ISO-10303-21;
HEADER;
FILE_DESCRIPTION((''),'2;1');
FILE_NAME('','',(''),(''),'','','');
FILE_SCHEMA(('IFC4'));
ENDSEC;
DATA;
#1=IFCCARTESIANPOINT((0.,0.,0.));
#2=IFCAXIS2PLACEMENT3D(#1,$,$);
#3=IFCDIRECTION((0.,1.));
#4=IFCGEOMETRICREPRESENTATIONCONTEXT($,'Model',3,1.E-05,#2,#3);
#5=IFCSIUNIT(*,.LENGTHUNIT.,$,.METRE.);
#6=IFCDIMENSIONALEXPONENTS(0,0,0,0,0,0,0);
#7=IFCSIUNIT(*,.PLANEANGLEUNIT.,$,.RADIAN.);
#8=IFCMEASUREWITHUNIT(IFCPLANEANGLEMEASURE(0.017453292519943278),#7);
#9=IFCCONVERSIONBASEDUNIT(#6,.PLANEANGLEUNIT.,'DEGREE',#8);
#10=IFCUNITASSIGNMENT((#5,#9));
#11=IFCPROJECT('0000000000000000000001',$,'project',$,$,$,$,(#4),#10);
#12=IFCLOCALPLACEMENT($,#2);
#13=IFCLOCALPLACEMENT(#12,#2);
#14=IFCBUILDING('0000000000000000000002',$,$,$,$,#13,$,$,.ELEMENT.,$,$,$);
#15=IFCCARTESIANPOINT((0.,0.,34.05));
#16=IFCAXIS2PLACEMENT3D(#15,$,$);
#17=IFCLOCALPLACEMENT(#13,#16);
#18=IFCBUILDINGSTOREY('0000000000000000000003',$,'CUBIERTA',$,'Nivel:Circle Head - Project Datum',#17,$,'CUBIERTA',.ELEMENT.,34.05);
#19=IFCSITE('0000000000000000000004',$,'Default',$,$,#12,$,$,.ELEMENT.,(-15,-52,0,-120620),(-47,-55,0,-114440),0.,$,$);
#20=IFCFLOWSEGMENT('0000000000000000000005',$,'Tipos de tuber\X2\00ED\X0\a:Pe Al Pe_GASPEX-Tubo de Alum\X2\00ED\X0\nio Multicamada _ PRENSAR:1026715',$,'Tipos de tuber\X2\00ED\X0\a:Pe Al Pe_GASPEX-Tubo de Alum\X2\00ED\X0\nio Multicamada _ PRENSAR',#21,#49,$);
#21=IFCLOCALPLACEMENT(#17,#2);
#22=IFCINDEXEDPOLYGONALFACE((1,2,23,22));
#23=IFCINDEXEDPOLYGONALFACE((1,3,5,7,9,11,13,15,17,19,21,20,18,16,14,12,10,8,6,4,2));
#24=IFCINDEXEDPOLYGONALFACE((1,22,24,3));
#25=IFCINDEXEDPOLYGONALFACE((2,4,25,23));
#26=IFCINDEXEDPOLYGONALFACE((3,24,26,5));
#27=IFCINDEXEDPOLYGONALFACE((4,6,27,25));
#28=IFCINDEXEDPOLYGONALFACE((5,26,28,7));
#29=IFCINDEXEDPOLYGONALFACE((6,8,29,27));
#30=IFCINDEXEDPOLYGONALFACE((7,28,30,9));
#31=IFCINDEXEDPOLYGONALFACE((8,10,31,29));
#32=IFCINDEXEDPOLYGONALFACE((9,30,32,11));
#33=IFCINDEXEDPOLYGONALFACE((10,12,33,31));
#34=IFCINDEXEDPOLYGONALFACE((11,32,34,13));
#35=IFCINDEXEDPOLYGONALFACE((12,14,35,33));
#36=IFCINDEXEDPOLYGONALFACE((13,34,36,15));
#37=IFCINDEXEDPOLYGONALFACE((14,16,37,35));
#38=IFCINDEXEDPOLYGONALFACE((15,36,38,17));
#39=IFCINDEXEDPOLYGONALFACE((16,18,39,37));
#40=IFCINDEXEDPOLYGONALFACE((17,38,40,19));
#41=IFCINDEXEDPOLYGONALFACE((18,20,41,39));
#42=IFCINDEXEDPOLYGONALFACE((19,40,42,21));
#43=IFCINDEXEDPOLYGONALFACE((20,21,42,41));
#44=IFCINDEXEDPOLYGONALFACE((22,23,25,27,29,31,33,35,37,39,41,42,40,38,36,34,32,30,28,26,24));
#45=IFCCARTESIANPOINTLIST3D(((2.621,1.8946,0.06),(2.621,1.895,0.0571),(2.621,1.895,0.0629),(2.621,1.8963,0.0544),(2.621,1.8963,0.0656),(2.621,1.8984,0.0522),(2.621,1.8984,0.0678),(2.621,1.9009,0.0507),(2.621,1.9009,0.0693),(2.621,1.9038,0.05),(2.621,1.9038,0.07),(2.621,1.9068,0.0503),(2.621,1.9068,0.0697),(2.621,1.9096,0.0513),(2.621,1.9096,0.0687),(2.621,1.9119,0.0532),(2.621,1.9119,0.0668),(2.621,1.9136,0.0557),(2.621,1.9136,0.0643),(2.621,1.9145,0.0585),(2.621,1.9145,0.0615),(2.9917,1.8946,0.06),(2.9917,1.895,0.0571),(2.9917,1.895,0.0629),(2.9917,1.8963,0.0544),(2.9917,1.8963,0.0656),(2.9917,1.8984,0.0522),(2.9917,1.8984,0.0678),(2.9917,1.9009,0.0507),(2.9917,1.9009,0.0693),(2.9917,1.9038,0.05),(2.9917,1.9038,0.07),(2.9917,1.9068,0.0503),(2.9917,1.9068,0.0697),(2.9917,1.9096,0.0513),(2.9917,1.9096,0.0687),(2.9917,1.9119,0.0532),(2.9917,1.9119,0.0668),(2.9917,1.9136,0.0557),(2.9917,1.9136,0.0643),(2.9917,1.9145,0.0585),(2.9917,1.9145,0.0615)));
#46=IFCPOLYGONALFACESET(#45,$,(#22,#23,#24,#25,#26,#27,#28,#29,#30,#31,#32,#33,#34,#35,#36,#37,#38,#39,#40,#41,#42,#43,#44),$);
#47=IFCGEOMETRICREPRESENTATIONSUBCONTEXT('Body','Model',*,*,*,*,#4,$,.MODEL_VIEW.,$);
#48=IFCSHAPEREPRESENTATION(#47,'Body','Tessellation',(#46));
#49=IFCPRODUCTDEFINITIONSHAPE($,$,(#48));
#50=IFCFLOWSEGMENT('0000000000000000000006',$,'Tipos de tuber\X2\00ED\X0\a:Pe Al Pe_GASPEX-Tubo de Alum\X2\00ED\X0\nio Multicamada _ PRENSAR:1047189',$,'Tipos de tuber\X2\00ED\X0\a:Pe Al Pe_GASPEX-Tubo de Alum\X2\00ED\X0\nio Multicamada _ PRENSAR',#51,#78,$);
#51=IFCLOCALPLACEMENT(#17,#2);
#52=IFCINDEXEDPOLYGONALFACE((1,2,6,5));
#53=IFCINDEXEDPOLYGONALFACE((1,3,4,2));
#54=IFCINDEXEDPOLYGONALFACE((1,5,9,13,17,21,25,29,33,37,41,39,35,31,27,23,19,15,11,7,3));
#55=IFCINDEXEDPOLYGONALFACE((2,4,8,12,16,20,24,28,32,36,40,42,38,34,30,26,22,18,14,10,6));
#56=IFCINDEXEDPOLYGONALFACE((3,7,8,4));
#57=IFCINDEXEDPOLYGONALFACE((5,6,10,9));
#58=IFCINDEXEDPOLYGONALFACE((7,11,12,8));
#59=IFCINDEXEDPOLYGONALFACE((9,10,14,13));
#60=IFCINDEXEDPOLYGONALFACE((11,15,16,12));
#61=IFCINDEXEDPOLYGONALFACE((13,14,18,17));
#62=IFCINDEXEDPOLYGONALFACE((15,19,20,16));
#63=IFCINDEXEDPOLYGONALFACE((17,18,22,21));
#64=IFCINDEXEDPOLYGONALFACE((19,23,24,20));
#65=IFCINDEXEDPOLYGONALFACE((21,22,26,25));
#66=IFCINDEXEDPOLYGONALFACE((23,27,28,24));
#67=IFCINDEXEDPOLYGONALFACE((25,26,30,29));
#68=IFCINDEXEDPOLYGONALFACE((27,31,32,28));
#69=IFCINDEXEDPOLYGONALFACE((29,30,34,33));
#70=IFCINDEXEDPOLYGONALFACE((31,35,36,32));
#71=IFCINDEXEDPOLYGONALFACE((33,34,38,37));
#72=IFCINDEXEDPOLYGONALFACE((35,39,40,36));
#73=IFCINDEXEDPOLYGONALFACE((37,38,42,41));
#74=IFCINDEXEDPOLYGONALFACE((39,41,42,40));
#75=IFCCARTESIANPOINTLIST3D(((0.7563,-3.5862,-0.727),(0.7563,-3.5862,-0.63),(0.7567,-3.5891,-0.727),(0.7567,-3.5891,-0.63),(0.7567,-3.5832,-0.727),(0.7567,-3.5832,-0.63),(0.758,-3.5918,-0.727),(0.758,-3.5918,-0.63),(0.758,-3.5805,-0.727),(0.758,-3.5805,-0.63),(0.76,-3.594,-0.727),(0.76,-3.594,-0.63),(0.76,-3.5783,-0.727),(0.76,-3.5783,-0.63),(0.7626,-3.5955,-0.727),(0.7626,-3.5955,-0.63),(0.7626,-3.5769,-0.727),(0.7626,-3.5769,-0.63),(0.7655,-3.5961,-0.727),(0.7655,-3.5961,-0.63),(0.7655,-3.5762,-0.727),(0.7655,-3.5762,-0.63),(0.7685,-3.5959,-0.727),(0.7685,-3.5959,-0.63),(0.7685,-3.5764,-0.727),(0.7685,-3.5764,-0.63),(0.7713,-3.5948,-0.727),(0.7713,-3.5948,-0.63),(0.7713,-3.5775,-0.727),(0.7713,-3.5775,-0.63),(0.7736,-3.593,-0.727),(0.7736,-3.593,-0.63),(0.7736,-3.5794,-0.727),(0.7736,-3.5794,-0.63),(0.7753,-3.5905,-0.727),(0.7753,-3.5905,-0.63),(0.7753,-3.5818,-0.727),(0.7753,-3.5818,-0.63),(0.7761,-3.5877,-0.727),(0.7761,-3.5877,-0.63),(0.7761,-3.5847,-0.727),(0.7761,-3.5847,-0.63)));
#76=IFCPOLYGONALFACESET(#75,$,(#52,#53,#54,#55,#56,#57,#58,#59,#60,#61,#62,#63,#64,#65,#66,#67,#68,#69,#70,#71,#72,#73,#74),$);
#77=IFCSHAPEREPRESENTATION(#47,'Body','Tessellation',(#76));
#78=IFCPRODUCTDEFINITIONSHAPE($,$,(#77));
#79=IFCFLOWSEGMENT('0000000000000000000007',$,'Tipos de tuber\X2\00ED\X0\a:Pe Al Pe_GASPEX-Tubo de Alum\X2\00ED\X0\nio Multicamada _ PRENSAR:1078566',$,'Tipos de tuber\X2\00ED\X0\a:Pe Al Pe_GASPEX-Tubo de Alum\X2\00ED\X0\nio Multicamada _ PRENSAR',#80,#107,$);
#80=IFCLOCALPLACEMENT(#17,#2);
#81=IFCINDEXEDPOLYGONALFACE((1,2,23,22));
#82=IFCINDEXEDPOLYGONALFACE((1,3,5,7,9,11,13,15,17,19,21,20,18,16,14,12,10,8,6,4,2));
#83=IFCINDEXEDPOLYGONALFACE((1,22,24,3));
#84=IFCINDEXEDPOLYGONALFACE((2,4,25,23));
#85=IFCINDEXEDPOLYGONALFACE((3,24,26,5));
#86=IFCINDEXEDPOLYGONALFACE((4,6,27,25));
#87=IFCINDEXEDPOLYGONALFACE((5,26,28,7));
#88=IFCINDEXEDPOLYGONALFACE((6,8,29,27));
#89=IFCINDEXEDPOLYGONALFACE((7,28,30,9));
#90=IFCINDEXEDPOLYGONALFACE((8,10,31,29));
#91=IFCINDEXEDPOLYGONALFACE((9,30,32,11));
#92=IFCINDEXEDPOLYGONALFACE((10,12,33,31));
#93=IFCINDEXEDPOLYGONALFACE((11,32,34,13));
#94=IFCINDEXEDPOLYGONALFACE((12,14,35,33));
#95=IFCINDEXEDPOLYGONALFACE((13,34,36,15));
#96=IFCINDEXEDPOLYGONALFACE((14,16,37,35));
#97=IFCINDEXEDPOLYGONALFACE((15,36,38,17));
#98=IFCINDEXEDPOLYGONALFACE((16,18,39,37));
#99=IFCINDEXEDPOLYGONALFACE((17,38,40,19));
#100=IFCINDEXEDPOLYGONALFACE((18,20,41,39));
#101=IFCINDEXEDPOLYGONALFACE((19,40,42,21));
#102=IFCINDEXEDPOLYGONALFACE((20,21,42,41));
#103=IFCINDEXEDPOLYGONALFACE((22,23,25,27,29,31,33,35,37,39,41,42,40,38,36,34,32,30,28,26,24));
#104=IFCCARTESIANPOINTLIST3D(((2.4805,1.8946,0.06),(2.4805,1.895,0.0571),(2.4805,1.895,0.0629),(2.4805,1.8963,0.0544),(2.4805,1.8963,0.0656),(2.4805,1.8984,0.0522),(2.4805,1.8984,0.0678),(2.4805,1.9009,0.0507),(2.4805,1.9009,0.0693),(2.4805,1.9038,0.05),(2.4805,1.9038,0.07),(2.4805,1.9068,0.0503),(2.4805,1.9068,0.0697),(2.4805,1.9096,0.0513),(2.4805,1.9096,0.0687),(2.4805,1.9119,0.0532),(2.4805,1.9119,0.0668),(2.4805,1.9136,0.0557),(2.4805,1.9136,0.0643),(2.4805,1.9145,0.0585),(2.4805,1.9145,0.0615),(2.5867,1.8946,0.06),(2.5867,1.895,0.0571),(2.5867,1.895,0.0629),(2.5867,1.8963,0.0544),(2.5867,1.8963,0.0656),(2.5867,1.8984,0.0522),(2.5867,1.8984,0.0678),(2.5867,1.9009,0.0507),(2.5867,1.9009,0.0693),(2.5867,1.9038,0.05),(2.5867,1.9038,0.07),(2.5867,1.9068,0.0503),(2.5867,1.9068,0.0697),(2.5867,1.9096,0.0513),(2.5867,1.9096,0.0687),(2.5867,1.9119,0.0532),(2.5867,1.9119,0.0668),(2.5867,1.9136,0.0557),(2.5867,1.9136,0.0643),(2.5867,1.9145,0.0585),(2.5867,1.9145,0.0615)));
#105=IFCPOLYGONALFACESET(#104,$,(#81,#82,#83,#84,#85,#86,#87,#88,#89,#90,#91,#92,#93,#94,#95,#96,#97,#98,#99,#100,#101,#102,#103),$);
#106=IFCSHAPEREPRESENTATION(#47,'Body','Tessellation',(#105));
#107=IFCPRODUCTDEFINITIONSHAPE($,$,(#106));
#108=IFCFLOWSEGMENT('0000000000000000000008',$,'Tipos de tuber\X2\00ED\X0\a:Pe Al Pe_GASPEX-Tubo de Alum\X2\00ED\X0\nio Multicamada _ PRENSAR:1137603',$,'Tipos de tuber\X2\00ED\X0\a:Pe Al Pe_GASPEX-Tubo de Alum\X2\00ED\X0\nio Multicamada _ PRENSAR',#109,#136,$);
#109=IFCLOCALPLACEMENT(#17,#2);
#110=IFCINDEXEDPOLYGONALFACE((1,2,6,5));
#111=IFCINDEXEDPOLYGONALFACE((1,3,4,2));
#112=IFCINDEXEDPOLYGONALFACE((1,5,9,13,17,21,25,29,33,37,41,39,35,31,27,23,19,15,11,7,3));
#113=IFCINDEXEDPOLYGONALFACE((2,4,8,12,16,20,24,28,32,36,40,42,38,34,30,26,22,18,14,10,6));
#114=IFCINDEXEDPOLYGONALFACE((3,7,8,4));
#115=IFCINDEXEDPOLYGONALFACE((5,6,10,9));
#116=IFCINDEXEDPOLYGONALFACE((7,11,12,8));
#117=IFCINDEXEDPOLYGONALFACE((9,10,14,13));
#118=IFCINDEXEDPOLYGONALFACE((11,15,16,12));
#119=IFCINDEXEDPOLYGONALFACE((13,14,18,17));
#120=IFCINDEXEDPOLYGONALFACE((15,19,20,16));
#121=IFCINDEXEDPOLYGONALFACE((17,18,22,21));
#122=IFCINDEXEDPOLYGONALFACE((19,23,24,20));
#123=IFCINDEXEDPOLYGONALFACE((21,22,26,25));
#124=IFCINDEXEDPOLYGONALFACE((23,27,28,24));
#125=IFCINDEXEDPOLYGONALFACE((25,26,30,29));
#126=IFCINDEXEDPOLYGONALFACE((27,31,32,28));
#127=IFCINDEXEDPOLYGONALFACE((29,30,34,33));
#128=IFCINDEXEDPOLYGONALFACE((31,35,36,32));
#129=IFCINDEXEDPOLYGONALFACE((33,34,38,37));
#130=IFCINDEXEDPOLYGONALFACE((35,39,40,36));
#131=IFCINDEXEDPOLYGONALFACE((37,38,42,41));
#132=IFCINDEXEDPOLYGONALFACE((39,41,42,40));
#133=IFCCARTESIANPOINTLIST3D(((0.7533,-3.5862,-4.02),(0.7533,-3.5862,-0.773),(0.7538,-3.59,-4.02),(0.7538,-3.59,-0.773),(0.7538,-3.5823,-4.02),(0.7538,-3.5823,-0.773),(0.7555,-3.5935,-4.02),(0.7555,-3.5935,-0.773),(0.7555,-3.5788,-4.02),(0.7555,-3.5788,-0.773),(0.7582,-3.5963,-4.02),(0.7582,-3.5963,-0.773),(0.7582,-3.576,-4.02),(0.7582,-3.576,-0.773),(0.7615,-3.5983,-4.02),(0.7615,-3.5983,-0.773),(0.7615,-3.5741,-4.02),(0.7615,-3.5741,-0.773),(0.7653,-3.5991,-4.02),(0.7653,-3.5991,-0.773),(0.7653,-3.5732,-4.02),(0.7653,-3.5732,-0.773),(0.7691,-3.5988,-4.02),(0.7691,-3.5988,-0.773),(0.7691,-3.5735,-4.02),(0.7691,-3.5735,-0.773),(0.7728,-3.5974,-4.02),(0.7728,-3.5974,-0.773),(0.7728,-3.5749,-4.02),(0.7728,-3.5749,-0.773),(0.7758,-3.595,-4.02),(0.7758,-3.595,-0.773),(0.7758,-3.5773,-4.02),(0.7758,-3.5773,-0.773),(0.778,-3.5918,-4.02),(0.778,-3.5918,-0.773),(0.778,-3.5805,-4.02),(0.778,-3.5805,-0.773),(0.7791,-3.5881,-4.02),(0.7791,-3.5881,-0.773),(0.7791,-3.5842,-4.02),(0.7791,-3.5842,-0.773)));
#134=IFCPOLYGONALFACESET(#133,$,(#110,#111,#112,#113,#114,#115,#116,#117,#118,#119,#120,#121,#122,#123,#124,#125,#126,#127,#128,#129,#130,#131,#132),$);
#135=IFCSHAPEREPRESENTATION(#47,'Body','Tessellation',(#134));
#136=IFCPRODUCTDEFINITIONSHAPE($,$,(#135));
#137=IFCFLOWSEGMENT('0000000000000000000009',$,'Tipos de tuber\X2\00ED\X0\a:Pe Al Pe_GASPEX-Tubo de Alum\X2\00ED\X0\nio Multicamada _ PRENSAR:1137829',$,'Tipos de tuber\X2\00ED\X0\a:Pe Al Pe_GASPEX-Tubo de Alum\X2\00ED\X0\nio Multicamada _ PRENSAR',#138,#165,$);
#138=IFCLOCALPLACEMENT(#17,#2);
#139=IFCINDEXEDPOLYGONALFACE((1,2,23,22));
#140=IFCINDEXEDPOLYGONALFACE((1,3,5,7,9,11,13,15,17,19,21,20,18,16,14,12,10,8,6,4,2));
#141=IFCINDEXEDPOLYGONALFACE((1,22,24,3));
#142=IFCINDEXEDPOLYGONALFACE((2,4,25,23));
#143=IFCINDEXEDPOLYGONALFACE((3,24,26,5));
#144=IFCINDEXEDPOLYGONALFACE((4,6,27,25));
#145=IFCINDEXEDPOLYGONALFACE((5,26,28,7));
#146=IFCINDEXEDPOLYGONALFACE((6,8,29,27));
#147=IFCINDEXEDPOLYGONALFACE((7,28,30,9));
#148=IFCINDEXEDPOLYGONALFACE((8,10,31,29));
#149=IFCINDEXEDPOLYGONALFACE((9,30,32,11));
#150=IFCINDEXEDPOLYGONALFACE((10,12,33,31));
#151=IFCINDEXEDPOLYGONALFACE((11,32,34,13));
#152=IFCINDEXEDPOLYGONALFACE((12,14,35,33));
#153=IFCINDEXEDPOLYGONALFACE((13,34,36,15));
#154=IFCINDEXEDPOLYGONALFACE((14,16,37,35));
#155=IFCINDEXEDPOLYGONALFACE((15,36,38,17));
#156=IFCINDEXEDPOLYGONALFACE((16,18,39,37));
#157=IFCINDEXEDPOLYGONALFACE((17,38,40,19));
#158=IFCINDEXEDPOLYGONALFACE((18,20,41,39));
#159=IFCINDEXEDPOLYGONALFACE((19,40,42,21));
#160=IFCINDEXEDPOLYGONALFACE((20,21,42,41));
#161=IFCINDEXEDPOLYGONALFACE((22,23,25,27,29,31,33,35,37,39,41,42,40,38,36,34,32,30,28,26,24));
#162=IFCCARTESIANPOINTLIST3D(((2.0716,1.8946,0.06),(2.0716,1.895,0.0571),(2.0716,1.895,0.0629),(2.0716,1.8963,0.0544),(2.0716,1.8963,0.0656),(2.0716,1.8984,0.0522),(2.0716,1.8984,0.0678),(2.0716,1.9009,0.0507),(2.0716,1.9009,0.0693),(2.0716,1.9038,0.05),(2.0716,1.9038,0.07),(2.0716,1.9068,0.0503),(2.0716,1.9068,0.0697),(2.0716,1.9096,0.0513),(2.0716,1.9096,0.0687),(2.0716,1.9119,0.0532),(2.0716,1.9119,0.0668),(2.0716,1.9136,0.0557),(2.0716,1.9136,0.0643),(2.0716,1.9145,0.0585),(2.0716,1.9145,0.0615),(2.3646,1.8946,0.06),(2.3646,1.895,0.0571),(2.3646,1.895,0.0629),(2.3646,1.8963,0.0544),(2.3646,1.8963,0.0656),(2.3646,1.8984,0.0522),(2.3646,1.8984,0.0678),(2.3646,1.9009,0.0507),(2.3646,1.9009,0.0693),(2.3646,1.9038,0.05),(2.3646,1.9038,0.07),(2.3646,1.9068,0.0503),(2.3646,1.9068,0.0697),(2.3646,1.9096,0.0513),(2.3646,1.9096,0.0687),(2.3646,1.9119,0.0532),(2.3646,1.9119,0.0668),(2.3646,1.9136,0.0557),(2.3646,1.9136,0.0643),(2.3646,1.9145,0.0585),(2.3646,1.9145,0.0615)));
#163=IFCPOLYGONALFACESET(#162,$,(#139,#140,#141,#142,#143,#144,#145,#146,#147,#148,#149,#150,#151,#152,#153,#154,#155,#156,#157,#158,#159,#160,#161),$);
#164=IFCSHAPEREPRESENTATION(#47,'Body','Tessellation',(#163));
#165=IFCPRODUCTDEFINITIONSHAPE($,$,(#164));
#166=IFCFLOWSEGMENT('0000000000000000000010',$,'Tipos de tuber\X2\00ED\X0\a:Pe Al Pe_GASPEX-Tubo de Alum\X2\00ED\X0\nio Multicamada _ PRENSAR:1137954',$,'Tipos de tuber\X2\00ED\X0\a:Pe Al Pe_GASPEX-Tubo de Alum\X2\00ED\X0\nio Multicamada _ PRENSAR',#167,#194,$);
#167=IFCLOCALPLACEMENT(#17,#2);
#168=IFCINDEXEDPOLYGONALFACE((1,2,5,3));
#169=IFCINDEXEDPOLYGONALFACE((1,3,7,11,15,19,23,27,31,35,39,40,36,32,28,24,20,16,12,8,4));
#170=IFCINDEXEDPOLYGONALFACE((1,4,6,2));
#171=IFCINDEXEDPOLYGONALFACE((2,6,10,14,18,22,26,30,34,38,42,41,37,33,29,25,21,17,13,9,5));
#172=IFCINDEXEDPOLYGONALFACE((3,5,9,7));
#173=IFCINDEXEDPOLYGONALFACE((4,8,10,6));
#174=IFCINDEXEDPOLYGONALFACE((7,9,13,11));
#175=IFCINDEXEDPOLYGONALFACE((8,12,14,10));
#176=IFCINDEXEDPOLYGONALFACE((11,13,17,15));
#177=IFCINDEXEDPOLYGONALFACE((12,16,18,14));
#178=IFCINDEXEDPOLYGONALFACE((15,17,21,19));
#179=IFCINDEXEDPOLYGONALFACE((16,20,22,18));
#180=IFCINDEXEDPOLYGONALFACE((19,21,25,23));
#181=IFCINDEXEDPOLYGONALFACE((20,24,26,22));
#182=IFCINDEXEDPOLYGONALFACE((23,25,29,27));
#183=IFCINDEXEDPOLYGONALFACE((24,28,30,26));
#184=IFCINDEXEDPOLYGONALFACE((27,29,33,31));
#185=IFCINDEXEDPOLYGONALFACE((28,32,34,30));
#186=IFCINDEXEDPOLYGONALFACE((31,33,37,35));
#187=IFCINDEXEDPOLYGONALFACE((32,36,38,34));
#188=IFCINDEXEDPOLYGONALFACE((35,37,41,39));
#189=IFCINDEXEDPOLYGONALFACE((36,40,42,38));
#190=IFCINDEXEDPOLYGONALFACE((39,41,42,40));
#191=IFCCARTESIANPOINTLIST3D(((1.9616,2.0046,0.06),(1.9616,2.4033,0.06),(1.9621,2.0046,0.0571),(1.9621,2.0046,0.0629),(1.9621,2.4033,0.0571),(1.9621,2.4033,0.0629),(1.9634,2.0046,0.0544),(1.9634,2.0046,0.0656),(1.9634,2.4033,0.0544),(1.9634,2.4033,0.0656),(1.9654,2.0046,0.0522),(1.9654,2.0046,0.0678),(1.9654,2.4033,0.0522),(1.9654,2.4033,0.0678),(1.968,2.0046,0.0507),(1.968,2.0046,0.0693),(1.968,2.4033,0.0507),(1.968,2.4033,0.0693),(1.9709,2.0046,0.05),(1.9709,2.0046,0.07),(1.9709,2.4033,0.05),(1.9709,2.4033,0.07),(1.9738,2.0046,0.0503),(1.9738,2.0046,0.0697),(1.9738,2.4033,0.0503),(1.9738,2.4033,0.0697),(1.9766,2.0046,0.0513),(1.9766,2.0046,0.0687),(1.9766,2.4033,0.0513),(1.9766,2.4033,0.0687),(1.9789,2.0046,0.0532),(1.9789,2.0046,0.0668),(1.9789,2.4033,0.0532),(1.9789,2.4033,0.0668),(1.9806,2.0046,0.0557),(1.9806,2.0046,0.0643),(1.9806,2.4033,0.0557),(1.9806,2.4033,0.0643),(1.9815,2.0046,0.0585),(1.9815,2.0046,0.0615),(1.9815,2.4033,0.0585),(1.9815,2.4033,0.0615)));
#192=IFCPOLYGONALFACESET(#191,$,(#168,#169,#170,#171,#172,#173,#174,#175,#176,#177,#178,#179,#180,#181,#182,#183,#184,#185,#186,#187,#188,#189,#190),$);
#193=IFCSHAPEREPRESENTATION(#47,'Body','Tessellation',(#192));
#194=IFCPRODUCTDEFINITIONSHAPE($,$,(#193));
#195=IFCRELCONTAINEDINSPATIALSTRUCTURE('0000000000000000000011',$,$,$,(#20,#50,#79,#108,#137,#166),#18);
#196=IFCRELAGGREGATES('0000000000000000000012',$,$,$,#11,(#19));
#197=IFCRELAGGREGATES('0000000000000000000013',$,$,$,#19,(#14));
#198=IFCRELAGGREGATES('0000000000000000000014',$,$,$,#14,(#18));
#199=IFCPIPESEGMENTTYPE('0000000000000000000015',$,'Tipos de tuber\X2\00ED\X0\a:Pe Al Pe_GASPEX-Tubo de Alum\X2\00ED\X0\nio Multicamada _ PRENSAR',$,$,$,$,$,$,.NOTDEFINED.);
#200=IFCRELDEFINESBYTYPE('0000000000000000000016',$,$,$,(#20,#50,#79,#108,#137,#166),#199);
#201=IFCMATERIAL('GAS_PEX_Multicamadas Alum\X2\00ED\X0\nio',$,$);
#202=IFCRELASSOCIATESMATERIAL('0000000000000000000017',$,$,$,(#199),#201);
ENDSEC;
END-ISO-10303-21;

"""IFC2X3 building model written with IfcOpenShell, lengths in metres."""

from ifc_helpers import new_model, entity, si_unit, converted_unit, direction, frame, frame_2d, origin, origin_2d_with_axis, place, context, subcontext, project, spatial, circle, extrude, material, type_object, element, save


model = new_model("IFC2X3")

# Units and contexts
model_context = context("Model", 3, precision=1e-05, world=origin(), true_north=direction((0.0, 1.0)))
body_context = subcontext(model_context, "Body", "Model", "MODEL_VIEW")
ifc_project = project(units=[si_unit("LENGTHUNIT", "METRE"), converted_unit("PLANEANGLEUNIT", "DEGREE", entity("IfcPlaneAngleMeasure", 0.017453292519943278), si_unit("PLANEANGLEUNIT", "RADIAN"), dimensions=[0, 0, 0, 0, 0, 0, 0])], contexts=[model_context])

# Site, building, storey
site_placement = place(None, origin())
site = spatial("IfcSite", under=ifc_project, at=site_placement, Name="Default", CompositionType="ELEMENT", RefLatitude=(-15, -52, 0, -120620), RefLongitude=(-47, -55, 0, -114440), RefElevation=0.0)
building_placement = place(site_placement, origin())
building = spatial("IfcBuilding", under=site, at=building_placement, CompositionType="ELEMENT")
storey_placement = place(building_placement, frame((0.0, 0.0, 34.05)))
storey = spatial("IfcBuildingStorey", under=building, at=storey_placement, Name="CUBIERTA", ObjectType="Nivel:Circle Head - Project Datum", LongName="CUBIERTA", CompositionType="ELEMENT", Elevation=34.05)

# Flow segments
ifc_material = material(Name="GAS_PEX_Multicamadas Alumínio")
pipe_segment_type = type_object("IfcPipeSegmentType", Name="Tipos de tubería:Pe Al Pe_GASPEX-Tubo de Alumínio Multicamada _ PRENSAR", PredefinedType="NOTDEFINED", material=ifc_material)
flow_segment_1_placement = place(storey_placement, origin())
element("IfcFlowSegment", 1, at=flow_segment_1_placement, inside=storey, type_object=pipe_segment_type, Name="Tipos de tubería:Pe Al Pe_GASPEX-Tubo de Alumínio Multicamada _ PRENSAR:1026715", ObjectType="Tipos de tubería:Pe Al Pe_GASPEX-Tubo de Alumínio Multicamada _ PRENSAR", context=body_context, shape_type="SweptSolid", body=[
    extrude(circle(Radius=0.01, at=frame_2d((0.0, 0.0), x_axis=(1.0, 0.0))), frame((2.621, 1.9046, 0.06), z_axis=(1.0, 0.0, 0.0), x_axis=(0.0, -1.0, 0.0)), (0.0, 0.0, 1.0), 0.3707),
])
flow_segment_2_placement = place(storey_placement, origin())
element("IfcFlowSegment", 2, at=flow_segment_2_placement, inside=storey, type_object=pipe_segment_type, Name="Tipos de tubería:Pe Al Pe_GASPEX-Tubo de Alumínio Multicamada _ PRENSAR:1047189", ObjectType="Tipos de tubería:Pe Al Pe_GASPEX-Tubo de Alumínio Multicamada _ PRENSAR", context=body_context, shape_type="SweptSolid", body=[
    extrude(circle(Radius=0.01, at=origin_2d_with_axis()), frame((0.7663, -3.5862, -0.727), z_axis=(0.0, 0.0, 1.0), x_axis=(-1.0, 0.0, 0.0)), (0.0, 0.0, 1.0), 0.097),
])
flow_segment_3_placement = place(storey_placement, origin())
element("IfcFlowSegment", 3, at=flow_segment_3_placement, inside=storey, type_object=pipe_segment_type, Name="Tipos de tubería:Pe Al Pe_GASPEX-Tubo de Alumínio Multicamada _ PRENSAR:1078566", ObjectType="Tipos de tubería:Pe Al Pe_GASPEX-Tubo de Alumínio Multicamada _ PRENSAR", context=body_context, shape_type="SweptSolid", body=[
    extrude(circle(Radius=0.01, at=frame_2d((0.0, 0.0), x_axis=(1.0, 0.0))), frame((2.4805, 1.9046, 0.06), z_axis=(1.0, 0.0, 0.0), x_axis=(0.0, -1.0, 0.0)), (0.0, 0.0, 1.0), 0.1062),
])
flow_segment_4_placement = place(storey_placement, origin())
element("IfcFlowSegment", 4, at=flow_segment_4_placement, inside=storey, type_object=pipe_segment_type, Name="Tipos de tubería:Pe Al Pe_GASPEX-Tubo de Alumínio Multicamada _ PRENSAR:1137603", ObjectType="Tipos de tubería:Pe Al Pe_GASPEX-Tubo de Alumínio Multicamada _ PRENSAR", context=body_context, shape_type="SweptSolid", body=[
    extrude(circle(Radius=0.013, at=origin_2d_with_axis()), frame((0.7663, -3.5862, -4.02), z_axis=(0.0, 0.0, 1.0), x_axis=(-1.0, 0.0, 0.0)), (0.0, 0.0, 1.0), 3.247),
])
flow_segment_5_placement = place(storey_placement, origin())
element("IfcFlowSegment", 5, at=flow_segment_5_placement, inside=storey, type_object=pipe_segment_type, Name="Tipos de tubería:Pe Al Pe_GASPEX-Tubo de Alumínio Multicamada _ PRENSAR:1137829", ObjectType="Tipos de tubería:Pe Al Pe_GASPEX-Tubo de Alumínio Multicamada _ PRENSAR", context=body_context, shape_type="SweptSolid", body=[
    extrude(circle(Radius=0.01, at=frame_2d((0.0, 0.0), x_axis=(1.0, 0.0))), frame((2.0716, 1.9046, 0.06), z_axis=(1.0, 0.0, 0.0), x_axis=(0.0, -1.0, 0.0)), (0.0, 0.0, 1.0), 0.293),
])
flow_segment_6_placement = place(storey_placement, origin())
element("IfcFlowSegment", 6, at=flow_segment_6_placement, inside=storey, type_object=pipe_segment_type, Name="Tipos de tubería:Pe Al Pe_GASPEX-Tubo de Alumínio Multicamada _ PRENSAR:1137954", ObjectType="Tipos de tubería:Pe Al Pe_GASPEX-Tubo de Alumínio Multicamada _ PRENSAR", context=body_context, shape_type="SweptSolid", body=[
    extrude(circle(Radius=0.01, at=frame_2d((0.0, 0.0), x_axis=(1.0, 0.0))), frame((1.9716, 2.0046, 0.06), z_axis=(0.0, 1.0, 0.0), x_axis=(-1.0, 0.0, 0.0)), (0.0, 0.0, 1.0), 0.3988),
])

save(model, "model.ifc")
